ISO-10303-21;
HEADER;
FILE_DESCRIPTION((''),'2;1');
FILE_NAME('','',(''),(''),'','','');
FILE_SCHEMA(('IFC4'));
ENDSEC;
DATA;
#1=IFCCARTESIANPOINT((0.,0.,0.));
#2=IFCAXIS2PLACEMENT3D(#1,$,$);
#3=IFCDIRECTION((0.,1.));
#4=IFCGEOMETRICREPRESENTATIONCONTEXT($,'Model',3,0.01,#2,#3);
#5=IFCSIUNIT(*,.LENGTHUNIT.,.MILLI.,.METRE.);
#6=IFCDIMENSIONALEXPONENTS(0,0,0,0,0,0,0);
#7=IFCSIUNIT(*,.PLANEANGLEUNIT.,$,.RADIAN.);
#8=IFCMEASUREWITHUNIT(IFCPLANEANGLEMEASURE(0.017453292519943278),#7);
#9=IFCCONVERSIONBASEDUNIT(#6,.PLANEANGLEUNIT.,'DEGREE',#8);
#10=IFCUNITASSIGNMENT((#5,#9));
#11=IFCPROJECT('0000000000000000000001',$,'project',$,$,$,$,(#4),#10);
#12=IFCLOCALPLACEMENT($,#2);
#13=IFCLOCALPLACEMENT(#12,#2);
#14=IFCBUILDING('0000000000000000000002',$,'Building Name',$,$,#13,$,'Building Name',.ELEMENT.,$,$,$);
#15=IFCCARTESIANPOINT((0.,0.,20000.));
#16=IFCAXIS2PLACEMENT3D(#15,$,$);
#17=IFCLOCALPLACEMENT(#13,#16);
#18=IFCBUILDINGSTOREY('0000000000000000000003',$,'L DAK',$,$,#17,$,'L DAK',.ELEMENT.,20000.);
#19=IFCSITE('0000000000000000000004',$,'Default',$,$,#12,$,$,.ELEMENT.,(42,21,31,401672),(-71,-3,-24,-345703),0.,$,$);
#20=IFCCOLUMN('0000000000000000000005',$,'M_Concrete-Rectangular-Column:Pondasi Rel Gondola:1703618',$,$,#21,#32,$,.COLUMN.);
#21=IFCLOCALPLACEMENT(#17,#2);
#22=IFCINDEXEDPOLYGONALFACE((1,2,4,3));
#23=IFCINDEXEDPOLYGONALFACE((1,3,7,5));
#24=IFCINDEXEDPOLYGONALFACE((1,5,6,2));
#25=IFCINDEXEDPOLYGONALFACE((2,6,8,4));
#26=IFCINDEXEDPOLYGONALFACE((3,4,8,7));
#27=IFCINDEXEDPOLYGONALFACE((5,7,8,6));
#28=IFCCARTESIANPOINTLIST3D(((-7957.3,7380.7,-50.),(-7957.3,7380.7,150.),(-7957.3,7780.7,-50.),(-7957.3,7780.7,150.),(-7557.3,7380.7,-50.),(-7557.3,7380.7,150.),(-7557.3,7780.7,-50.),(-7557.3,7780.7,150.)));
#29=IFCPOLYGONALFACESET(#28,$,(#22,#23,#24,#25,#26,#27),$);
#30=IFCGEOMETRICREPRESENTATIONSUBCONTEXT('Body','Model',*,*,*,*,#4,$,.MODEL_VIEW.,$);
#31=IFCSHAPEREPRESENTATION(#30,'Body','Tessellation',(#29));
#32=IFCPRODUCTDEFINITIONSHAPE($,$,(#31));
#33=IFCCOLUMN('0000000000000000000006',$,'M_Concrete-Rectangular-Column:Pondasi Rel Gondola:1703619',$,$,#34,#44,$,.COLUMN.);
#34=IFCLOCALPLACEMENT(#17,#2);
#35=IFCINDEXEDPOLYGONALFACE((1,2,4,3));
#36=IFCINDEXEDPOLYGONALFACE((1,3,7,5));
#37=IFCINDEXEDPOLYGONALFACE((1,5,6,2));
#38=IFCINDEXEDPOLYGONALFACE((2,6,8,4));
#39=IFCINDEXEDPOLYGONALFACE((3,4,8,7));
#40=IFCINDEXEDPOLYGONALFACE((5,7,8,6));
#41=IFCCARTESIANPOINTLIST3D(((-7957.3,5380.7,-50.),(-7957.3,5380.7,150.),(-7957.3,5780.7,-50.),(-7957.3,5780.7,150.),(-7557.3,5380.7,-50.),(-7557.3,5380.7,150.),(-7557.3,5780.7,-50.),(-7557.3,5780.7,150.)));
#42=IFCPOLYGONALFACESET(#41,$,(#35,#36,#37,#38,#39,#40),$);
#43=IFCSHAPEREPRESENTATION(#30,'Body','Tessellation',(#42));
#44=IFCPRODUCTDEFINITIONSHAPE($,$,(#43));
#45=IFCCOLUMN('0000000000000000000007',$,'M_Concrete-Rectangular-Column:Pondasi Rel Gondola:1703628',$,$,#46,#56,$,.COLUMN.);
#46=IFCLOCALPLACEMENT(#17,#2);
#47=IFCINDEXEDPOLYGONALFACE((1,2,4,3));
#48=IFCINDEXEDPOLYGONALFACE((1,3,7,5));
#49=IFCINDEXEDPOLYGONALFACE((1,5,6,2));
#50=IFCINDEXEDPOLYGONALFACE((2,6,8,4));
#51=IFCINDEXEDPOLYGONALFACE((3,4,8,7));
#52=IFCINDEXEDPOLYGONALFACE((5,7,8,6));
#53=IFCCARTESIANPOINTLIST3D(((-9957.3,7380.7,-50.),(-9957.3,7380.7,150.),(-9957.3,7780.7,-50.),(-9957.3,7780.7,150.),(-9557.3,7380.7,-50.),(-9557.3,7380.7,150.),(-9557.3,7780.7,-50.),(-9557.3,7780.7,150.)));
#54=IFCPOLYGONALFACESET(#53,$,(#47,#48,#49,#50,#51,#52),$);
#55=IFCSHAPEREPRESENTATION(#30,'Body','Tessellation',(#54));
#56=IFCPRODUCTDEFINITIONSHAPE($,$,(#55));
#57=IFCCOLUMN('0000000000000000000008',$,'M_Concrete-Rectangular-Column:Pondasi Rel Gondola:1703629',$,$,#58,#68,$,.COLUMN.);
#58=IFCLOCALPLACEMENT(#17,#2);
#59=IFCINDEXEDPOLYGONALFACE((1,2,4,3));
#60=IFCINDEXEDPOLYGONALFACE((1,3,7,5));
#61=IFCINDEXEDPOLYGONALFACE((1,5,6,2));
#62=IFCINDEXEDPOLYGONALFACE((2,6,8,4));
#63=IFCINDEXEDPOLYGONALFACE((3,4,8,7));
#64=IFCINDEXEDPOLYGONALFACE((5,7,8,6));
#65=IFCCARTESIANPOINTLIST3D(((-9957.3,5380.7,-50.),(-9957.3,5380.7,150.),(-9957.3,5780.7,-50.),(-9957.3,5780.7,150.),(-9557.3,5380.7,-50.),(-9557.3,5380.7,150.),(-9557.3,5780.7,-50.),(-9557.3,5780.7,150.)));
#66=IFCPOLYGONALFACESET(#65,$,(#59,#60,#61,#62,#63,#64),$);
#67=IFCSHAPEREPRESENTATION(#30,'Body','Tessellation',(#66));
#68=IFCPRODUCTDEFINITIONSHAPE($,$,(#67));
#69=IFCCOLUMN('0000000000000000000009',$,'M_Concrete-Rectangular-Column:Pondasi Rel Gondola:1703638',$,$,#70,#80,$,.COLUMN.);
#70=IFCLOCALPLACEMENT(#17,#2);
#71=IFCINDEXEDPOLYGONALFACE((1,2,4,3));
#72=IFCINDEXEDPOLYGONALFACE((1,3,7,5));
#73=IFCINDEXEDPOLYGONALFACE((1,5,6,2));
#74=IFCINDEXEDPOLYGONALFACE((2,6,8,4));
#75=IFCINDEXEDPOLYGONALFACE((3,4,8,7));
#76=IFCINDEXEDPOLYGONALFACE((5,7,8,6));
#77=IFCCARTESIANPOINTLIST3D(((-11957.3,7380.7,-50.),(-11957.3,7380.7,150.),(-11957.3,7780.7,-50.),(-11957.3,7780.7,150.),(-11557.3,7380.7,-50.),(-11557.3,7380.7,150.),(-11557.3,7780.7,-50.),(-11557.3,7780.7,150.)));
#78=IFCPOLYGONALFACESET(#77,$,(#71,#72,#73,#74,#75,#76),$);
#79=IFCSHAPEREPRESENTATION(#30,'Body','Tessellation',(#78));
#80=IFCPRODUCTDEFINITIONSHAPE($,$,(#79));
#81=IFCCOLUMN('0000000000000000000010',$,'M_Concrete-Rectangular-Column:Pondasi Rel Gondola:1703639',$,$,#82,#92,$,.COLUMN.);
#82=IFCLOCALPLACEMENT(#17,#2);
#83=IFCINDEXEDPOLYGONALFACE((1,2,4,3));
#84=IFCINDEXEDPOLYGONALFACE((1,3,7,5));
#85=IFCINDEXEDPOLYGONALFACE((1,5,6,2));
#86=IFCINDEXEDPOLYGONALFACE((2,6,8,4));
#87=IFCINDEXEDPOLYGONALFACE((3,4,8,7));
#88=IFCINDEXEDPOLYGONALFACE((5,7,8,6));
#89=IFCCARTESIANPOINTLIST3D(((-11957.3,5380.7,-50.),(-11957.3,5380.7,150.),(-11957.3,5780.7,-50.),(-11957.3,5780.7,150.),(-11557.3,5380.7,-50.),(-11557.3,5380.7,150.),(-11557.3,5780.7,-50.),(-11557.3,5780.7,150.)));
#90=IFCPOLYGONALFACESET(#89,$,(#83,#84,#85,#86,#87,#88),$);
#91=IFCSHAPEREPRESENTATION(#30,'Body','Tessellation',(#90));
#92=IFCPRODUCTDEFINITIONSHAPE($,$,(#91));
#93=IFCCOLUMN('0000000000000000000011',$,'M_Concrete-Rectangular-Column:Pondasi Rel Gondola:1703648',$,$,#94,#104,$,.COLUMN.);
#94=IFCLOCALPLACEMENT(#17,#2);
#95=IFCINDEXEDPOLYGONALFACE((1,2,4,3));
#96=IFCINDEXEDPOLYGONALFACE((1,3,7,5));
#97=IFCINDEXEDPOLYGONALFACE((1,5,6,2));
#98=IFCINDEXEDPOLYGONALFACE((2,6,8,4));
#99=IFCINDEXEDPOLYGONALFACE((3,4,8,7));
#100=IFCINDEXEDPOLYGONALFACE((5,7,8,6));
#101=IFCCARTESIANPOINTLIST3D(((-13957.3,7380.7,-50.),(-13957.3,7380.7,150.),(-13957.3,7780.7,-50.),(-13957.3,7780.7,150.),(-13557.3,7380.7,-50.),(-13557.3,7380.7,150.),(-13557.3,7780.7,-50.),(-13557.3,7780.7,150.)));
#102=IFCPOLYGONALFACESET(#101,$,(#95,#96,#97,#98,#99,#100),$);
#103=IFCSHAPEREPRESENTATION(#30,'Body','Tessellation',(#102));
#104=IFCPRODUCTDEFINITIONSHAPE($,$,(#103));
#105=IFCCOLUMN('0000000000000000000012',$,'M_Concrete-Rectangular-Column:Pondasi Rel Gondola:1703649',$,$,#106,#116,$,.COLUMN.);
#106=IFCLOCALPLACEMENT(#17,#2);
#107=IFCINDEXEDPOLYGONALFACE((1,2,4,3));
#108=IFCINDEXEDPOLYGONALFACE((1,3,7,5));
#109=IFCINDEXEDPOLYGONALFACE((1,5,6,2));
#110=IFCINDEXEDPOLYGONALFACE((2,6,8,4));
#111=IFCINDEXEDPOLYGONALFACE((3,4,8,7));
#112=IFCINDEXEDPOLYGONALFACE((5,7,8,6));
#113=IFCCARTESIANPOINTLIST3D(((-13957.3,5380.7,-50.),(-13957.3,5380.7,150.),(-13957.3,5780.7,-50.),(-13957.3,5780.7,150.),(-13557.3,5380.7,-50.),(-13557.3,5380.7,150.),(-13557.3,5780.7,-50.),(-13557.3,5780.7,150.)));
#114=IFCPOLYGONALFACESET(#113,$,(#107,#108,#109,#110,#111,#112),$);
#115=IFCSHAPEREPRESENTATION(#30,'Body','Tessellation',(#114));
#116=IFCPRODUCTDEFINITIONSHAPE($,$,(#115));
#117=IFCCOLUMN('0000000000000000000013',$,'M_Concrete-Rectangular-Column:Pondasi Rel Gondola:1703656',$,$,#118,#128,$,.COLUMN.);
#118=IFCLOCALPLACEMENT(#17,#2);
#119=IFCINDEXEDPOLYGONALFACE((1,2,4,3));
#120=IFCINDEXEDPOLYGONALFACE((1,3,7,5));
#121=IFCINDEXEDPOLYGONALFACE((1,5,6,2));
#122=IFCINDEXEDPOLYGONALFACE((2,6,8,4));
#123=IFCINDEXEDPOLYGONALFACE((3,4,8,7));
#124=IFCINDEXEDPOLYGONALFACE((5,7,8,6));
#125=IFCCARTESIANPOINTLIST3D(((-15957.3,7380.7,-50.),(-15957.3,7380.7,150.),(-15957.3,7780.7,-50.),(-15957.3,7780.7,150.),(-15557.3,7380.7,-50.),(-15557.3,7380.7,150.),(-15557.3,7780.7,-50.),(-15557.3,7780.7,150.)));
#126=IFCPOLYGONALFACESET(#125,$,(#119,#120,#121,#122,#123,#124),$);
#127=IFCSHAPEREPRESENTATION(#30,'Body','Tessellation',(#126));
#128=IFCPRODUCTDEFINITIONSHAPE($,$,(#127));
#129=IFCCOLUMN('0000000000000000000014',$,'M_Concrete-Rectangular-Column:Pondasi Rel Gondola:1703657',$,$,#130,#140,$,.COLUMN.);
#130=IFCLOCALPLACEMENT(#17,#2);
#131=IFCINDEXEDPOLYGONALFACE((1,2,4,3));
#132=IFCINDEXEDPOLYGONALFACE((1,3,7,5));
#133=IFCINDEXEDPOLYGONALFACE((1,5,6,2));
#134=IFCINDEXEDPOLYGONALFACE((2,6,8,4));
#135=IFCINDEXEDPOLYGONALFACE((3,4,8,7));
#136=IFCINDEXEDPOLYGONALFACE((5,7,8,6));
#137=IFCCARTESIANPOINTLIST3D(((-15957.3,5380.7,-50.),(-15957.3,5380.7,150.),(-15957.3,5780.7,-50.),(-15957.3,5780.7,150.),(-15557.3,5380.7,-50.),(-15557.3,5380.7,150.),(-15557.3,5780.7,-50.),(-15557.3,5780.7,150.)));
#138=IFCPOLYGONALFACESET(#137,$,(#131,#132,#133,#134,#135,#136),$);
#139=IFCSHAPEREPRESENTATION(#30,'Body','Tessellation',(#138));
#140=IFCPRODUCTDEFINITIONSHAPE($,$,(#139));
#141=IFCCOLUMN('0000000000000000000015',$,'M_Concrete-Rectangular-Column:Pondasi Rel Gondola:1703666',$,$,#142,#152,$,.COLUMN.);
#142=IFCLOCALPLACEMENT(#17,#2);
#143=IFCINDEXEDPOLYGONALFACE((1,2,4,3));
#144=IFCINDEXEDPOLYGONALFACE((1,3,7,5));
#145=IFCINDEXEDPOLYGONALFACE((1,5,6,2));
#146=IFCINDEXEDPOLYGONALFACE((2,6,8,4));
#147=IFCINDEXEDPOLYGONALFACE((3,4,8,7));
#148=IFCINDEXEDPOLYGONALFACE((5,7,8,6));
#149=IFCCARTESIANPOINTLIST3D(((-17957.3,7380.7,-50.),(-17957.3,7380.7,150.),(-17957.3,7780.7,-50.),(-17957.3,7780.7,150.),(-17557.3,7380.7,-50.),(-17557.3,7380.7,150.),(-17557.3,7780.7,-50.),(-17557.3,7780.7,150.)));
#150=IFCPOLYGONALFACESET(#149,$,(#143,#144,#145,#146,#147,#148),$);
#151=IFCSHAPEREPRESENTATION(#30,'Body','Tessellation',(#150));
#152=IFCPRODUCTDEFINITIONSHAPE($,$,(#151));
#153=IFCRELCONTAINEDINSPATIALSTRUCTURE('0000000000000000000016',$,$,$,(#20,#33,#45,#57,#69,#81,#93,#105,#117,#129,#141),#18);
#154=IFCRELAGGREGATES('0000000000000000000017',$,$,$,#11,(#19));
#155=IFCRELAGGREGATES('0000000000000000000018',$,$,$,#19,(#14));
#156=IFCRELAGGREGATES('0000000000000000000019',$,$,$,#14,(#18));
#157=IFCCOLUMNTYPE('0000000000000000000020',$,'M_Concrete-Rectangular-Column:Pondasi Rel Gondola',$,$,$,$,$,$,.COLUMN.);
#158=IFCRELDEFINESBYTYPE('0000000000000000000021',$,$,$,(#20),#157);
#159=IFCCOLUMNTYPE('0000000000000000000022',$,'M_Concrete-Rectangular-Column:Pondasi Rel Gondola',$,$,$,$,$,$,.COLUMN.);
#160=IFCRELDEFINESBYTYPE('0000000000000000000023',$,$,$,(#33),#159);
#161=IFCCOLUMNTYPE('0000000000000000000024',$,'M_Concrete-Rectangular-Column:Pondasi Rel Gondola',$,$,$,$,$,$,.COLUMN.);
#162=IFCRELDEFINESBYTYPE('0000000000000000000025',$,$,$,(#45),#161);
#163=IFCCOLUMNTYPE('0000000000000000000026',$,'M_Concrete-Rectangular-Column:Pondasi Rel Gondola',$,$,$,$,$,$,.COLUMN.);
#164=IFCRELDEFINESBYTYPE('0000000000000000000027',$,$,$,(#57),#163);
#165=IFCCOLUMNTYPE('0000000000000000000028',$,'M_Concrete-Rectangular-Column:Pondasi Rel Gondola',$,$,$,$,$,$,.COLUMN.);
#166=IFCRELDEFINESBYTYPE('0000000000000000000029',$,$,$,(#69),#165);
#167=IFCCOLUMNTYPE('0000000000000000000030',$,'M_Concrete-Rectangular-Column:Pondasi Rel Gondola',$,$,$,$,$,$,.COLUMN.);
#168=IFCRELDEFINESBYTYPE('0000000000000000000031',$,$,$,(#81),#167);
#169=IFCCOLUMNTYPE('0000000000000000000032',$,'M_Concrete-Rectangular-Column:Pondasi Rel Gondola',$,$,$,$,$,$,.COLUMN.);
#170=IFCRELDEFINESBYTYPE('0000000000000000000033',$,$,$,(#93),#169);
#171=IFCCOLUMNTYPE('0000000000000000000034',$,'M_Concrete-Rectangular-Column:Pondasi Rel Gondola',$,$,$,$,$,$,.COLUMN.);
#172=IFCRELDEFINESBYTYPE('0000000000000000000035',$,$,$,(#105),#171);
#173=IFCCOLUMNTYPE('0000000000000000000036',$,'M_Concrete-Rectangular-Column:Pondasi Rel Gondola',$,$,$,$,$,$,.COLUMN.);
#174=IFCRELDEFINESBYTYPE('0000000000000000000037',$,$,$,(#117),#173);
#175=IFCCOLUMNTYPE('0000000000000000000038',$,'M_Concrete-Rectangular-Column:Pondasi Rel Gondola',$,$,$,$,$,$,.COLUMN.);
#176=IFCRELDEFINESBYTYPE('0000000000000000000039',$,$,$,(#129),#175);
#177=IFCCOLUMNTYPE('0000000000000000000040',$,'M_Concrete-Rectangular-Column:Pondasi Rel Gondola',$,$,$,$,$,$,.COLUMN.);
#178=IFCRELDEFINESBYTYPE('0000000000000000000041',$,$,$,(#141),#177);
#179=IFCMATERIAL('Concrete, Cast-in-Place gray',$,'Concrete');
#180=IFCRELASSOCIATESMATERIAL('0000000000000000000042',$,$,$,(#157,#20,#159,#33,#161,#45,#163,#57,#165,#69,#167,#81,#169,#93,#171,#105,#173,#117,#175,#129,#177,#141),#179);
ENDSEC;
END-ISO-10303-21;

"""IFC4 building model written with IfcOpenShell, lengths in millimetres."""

from ifc_helpers import new_model, entity, si_unit, converted_unit, direction, frame, origin, place, context, subcontext, project, spatial, indexed_curve, outline, extrude, source, transform, mapped, material, type_object, type_shapes, element, save


model = new_model("IFC4")

# Units and contexts
model_context = context("Model", 3, precision=0.01, world=origin(), true_north=direction((0.0, 1.0)))
body_context = subcontext(model_context, "Body", "Model", "MODEL_VIEW")
ifc_project = project(units=[si_unit("LENGTHUNIT", "METRE", prefix="MILLI"), converted_unit("PLANEANGLEUNIT", "DEGREE", entity("IfcPlaneAngleMeasure", 0.017453292519943278), si_unit("PLANEANGLEUNIT", "RADIAN"), dimensions=[0, 0, 0, 0, 0, 0, 0])], contexts=[model_context])

# Site, building, storey
site_placement = place(None, origin())
site = spatial("IfcSite", under=ifc_project, at=site_placement, Name="Default", CompositionType="ELEMENT", RefLatitude=(42, 21, 31, 401672), RefLongitude=(-71, -3, -24, -345703), RefElevation=0.0)
building_placement = place(site_placement, origin())
building = spatial("IfcBuilding", under=site, at=building_placement, Name="Building Name", LongName="Building Name", CompositionType="ELEMENT")
storey_placement = place(building_placement, frame((0.0, 0.0, 20000.0)))
storey = spatial("IfcBuildingStorey", under=building, at=storey_placement, Name="L DAK", LongName="L DAK", CompositionType="ELEMENT", Elevation=20000.0)

# Columns
ifc_material = material(Name="Concrete, Cast-in-Place gray", Category="Concrete")
column_type_1 = type_object("IfcColumnType", Name="M_Concrete-Rectangular-Column:Pondasi Rel Gondola", PredefinedType="COLUMN", material=ifc_material)
shared_shape_1 = source(origin(), body_context, "Body", "SweptSolid", [
    extrude(outline(indexed_curve([(-200.0, -200.0), (200.0, -200.0), (200.0, 200.0), (-200.0, 200.0), (-200.0, -200.0)], self_intersect=False)), frame((-7757.3, 7580.7, 19950.0), z_axis=(0.0, 0.0, 1.0), x_axis=(-1.0, 0.0, 0.0)), (0.0, 0.0, 1.0), 200.0),
])
type_shapes(column_type_1, [shared_shape_1])
column_1_placement = place(storey_placement, frame((0.0, 0.0, -20000.0)))
element("IfcColumn", 1, at=column_1_placement, inside=storey, type_object=column_type_1, material=ifc_material, Name="M_Concrete-Rectangular-Column:Pondasi Rel Gondola:1703618", PredefinedType="COLUMN", context=body_context, shape_type="MappedRepresentation", body=[
    mapped(shared_shape_1, transform((0.0, 0.0, 0.0), scale=1.0)),
])
column_type_2 = type_object("IfcColumnType", Name="M_Concrete-Rectangular-Column:Pondasi Rel Gondola", PredefinedType="COLUMN", material=ifc_material)
shared_shape_2 = source(origin(), body_context, "Body", "SweptSolid", [
    extrude(outline(indexed_curve([(-200.0, -200.0), (200.0, -200.0), (200.0, 200.0), (-200.0, 200.0), (-200.0, -200.0)], self_intersect=False)), frame((-7757.3, 5580.7, 19950.0), z_axis=(0.0, 0.0, 1.0), x_axis=(-1.0, 0.0, 0.0)), (0.0, 0.0, 1.0), 200.0),
])
type_shapes(column_type_2, [shared_shape_2])
column_2_placement = place(storey_placement, frame((0.0, 0.0, -20000.0)))
element("IfcColumn", 2, at=column_2_placement, inside=storey, type_object=column_type_2, material=ifc_material, Name="M_Concrete-Rectangular-Column:Pondasi Rel Gondola:1703619", PredefinedType="COLUMN", context=body_context, shape_type="MappedRepresentation", body=[
    mapped(shared_shape_2, transform((0.0, 0.0, 0.0), scale=1.0)),
])
column_type_3 = type_object("IfcColumnType", Name="M_Concrete-Rectangular-Column:Pondasi Rel Gondola", PredefinedType="COLUMN", material=ifc_material)
shared_shape_3 = source(origin(), body_context, "Body", "SweptSolid", [
    extrude(outline(indexed_curve([(-200.0, -200.0), (200.0, -200.0), (200.0, 200.0), (-200.0, 200.0), (-200.0, -200.0)], self_intersect=False)), frame((-9757.3, 7580.7, 19950.0), z_axis=(0.0, 0.0, 1.0), x_axis=(-1.0, 0.0, 0.0)), (0.0, 0.0, 1.0), 200.0),
])
type_shapes(column_type_3, [shared_shape_3])
column_3_placement = place(storey_placement, frame((0.0, 0.0, -20000.0)))
element("IfcColumn", 3, at=column_3_placement, inside=storey, type_object=column_type_3, material=ifc_material, Name="M_Concrete-Rectangular-Column:Pondasi Rel Gondola:1703628", PredefinedType="COLUMN", context=body_context, shape_type="MappedRepresentation", body=[
    mapped(shared_shape_3, transform((0.0, 0.0, 0.0), scale=1.0)),
])
column_type_4 = type_object("IfcColumnType", Name="M_Concrete-Rectangular-Column:Pondasi Rel Gondola", PredefinedType="COLUMN", material=ifc_material)
shared_shape_4 = source(origin(), body_context, "Body", "SweptSolid", [
    extrude(outline(indexed_curve([(-200.0, -200.0), (200.0, -200.0), (200.0, 200.0), (-200.0, 200.0), (-200.0, -200.0)], self_intersect=False)), frame((-9757.3, 5580.7, 19950.0), z_axis=(0.0, 0.0, 1.0), x_axis=(-1.0, 0.0, 0.0)), (0.0, 0.0, 1.0), 200.0),
])
type_shapes(column_type_4, [shared_shape_4])
column_4_placement = place(storey_placement, frame((0.0, 0.0, -20000.0)))
element("IfcColumn", 4, at=column_4_placement, inside=storey, type_object=column_type_4, material=ifc_material, Name="M_Concrete-Rectangular-Column:Pondasi Rel Gondola:1703629", PredefinedType="COLUMN", context=body_context, shape_type="MappedRepresentation", body=[
    mapped(shared_shape_4, transform((0.0, 0.0, 0.0), scale=1.0)),
])
column_type_5 = type_object("IfcColumnType", Name="M_Concrete-Rectangular-Column:Pondasi Rel Gondola", PredefinedType="COLUMN", material=ifc_material)
shared_shape_5 = source(origin(), body_context, "Body", "SweptSolid", [
    extrude(outline(indexed_curve([(-200.0, -200.0), (200.0, -200.0), (200.0, 200.0), (-200.0, 200.0), (-200.0, -200.0)], self_intersect=False)), frame((-11757.3, 7580.7, 19950.0), z_axis=(0.0, 0.0, 1.0), x_axis=(-1.0, 0.0, 0.0)), (0.0, 0.0, 1.0), 200.0),
])
type_shapes(column_type_5, [shared_shape_5])
column_5_placement = place(storey_placement, frame((0.0, 0.0, -20000.0)))
element("IfcColumn", 5, at=column_5_placement, inside=storey, type_object=column_type_5, material=ifc_material, Name="M_Concrete-Rectangular-Column:Pondasi Rel Gondola:1703638", PredefinedType="COLUMN", context=body_context, shape_type="MappedRepresentation", body=[
    mapped(shared_shape_5, transform((0.0, 0.0, 0.0), scale=1.0)),
])
column_type_6 = type_object("IfcColumnType", Name="M_Concrete-Rectangular-Column:Pondasi Rel Gondola", PredefinedType="COLUMN", material=ifc_material)
shared_shape_6 = source(origin(), body_context, "Body", "SweptSolid", [
    extrude(outline(indexed_curve([(-200.0, -200.0), (200.0, -200.0), (200.0, 200.0), (-200.0, 200.0), (-200.0, -200.0)], self_intersect=False)), frame((-11757.3, 5580.7, 19950.0), z_axis=(0.0, 0.0, 1.0), x_axis=(-1.0, 0.0, 0.0)), (0.0, 0.0, 1.0), 200.0),
])
type_shapes(column_type_6, [shared_shape_6])
column_6_placement = place(storey_placement, frame((0.0, 0.0, -20000.0)))
element("IfcColumn", 6, at=column_6_placement, inside=storey, type_object=column_type_6, material=ifc_material, Name="M_Concrete-Rectangular-Column:Pondasi Rel Gondola:1703639", PredefinedType="COLUMN", context=body_context, shape_type="MappedRepresentation", body=[
    mapped(shared_shape_6, transform((0.0, 0.0, 0.0), scale=1.0)),
])
column_type_7 = type_object("IfcColumnType", Name="M_Concrete-Rectangular-Column:Pondasi Rel Gondola", PredefinedType="COLUMN", material=ifc_material)
shared_shape_7 = source(origin(), body_context, "Body", "SweptSolid", [
    extrude(outline(indexed_curve([(-200.0, -200.0), (200.0, -200.0), (200.0, 200.0), (-200.0, 200.0), (-200.0, -200.0)], self_intersect=False)), frame((-13757.3, 7580.7, 19950.0), z_axis=(0.0, 0.0, 1.0), x_axis=(-1.0, 0.0, 0.0)), (0.0, 0.0, 1.0), 200.0),
])
type_shapes(column_type_7, [shared_shape_7])
column_7_placement = place(storey_placement, frame((0.0, 0.0, -20000.0)))
element("IfcColumn", 7, at=column_7_placement, inside=storey, type_object=column_type_7, material=ifc_material, Name="M_Concrete-Rectangular-Column:Pondasi Rel Gondola:1703648", PredefinedType="COLUMN", context=body_context, shape_type="MappedRepresentation", body=[
    mapped(shared_shape_7, transform((0.0, 0.0, 0.0), scale=1.0)),
])
column_type_8 = type_object("IfcColumnType", Name="M_Concrete-Rectangular-Column:Pondasi Rel Gondola", PredefinedType="COLUMN", material=ifc_material)
shared_shape_8 = source(origin(), body_context, "Body", "SweptSolid", [
    extrude(outline(indexed_curve([(-200.0, -200.0), (200.0, -200.0), (200.0, 200.0), (-200.0, 200.0), (-200.0, -200.0)], self_intersect=False)), frame((-13757.3, 5580.7, 19950.0), z_axis=(0.0, 0.0, 1.0), x_axis=(-1.0, 0.0, 0.0)), (0.0, 0.0, 1.0), 200.0),
])
type_shapes(column_type_8, [shared_shape_8])
column_8_placement = place(storey_placement, frame((0.0, 0.0, -20000.0)))
element("IfcColumn", 8, at=column_8_placement, inside=storey, type_object=column_type_8, material=ifc_material, Name="M_Concrete-Rectangular-Column:Pondasi Rel Gondola:1703649", PredefinedType="COLUMN", context=body_context, shape_type="MappedRepresentation", body=[
    mapped(shared_shape_8, transform((0.0, 0.0, 0.0), scale=1.0)),
])
column_type_9 = type_object("IfcColumnType", Name="M_Concrete-Rectangular-Column:Pondasi Rel Gondola", PredefinedType="COLUMN", material=ifc_material)
shared_shape_9 = source(origin(), body_context, "Body", "SweptSolid", [
    extrude(outline(indexed_curve([(-200.0, -200.0), (200.0, -200.0), (200.0, 200.0), (-200.0, 200.0), (-200.0, -200.0)], self_intersect=False)), frame((-15757.3, 7580.7, 19950.0), z_axis=(0.0, 0.0, 1.0), x_axis=(-1.0, 0.0, 0.0)), (0.0, 0.0, 1.0), 200.0),
])
type_shapes(column_type_9, [shared_shape_9])
column_9_placement = place(storey_placement, frame((0.0, 0.0, -20000.0)))
element("IfcColumn", 9, at=column_9_placement, inside=storey, type_object=column_type_9, material=ifc_material, Name="M_Concrete-Rectangular-Column:Pondasi Rel Gondola:1703656", PredefinedType="COLUMN", context=body_context, shape_type="MappedRepresentation", body=[
    mapped(shared_shape_9, transform((0.0, 0.0, 0.0), scale=1.0)),
])
column_type_10 = type_object("IfcColumnType", Name="M_Concrete-Rectangular-Column:Pondasi Rel Gondola", PredefinedType="COLUMN", material=ifc_material)
shared_shape_10 = source(origin(), body_context, "Body", "SweptSolid", [
    extrude(outline(indexed_curve([(-200.0, -200.0), (200.0, -200.0), (200.0, 200.0), (-200.0, 200.0), (-200.0, -200.0)], self_intersect=False)), frame((-15757.3, 5580.7, 19950.0), z_axis=(0.0, 0.0, 1.0), x_axis=(-1.0, 0.0, 0.0)), (0.0, 0.0, 1.0), 200.0),
])
type_shapes(column_type_10, [shared_shape_10])
column_10_placement = place(storey_placement, frame((0.0, 0.0, -20000.0)))
element("IfcColumn", 10, at=column_10_placement, inside=storey, type_object=column_type_10, material=ifc_material, Name="M_Concrete-Rectangular-Column:Pondasi Rel Gondola:1703657", PredefinedType="COLUMN", context=body_context, shape_type="MappedRepresentation", body=[
    mapped(shared_shape_10, transform((0.0, 0.0, 0.0), scale=1.0)),
])
column_type_11 = type_object("IfcColumnType", Name="M_Concrete-Rectangular-Column:Pondasi Rel Gondola", PredefinedType="COLUMN", material=ifc_material)
shared_shape_11 = source(origin(), body_context, "Body", "SweptSolid", [
    extrude(outline(indexed_curve([(-200.0, -200.0), (200.0, -200.0), (200.0, 200.0), (-200.0, 200.0), (-200.0, -200.0)], self_intersect=False)), frame((-17757.3, 7580.7, 19950.0), z_axis=(0.0, 0.0, 1.0), x_axis=(-1.0, 0.0, 0.0)), (0.0, 0.0, 1.0), 200.0),
])
type_shapes(column_type_11, [shared_shape_11])
column_11_placement = place(storey_placement, frame((0.0, 0.0, -20000.0)))
element("IfcColumn", 11, at=column_11_placement, inside=storey, type_object=column_type_11, material=ifc_material, Name="M_Concrete-Rectangular-Column:Pondasi Rel Gondola:1703666", PredefinedType="COLUMN", context=body_context, shape_type="MappedRepresentation", body=[
    mapped(shared_shape_11, transform((0.0, 0.0, 0.0), scale=1.0)),
])

save(model, "model.ifc")
